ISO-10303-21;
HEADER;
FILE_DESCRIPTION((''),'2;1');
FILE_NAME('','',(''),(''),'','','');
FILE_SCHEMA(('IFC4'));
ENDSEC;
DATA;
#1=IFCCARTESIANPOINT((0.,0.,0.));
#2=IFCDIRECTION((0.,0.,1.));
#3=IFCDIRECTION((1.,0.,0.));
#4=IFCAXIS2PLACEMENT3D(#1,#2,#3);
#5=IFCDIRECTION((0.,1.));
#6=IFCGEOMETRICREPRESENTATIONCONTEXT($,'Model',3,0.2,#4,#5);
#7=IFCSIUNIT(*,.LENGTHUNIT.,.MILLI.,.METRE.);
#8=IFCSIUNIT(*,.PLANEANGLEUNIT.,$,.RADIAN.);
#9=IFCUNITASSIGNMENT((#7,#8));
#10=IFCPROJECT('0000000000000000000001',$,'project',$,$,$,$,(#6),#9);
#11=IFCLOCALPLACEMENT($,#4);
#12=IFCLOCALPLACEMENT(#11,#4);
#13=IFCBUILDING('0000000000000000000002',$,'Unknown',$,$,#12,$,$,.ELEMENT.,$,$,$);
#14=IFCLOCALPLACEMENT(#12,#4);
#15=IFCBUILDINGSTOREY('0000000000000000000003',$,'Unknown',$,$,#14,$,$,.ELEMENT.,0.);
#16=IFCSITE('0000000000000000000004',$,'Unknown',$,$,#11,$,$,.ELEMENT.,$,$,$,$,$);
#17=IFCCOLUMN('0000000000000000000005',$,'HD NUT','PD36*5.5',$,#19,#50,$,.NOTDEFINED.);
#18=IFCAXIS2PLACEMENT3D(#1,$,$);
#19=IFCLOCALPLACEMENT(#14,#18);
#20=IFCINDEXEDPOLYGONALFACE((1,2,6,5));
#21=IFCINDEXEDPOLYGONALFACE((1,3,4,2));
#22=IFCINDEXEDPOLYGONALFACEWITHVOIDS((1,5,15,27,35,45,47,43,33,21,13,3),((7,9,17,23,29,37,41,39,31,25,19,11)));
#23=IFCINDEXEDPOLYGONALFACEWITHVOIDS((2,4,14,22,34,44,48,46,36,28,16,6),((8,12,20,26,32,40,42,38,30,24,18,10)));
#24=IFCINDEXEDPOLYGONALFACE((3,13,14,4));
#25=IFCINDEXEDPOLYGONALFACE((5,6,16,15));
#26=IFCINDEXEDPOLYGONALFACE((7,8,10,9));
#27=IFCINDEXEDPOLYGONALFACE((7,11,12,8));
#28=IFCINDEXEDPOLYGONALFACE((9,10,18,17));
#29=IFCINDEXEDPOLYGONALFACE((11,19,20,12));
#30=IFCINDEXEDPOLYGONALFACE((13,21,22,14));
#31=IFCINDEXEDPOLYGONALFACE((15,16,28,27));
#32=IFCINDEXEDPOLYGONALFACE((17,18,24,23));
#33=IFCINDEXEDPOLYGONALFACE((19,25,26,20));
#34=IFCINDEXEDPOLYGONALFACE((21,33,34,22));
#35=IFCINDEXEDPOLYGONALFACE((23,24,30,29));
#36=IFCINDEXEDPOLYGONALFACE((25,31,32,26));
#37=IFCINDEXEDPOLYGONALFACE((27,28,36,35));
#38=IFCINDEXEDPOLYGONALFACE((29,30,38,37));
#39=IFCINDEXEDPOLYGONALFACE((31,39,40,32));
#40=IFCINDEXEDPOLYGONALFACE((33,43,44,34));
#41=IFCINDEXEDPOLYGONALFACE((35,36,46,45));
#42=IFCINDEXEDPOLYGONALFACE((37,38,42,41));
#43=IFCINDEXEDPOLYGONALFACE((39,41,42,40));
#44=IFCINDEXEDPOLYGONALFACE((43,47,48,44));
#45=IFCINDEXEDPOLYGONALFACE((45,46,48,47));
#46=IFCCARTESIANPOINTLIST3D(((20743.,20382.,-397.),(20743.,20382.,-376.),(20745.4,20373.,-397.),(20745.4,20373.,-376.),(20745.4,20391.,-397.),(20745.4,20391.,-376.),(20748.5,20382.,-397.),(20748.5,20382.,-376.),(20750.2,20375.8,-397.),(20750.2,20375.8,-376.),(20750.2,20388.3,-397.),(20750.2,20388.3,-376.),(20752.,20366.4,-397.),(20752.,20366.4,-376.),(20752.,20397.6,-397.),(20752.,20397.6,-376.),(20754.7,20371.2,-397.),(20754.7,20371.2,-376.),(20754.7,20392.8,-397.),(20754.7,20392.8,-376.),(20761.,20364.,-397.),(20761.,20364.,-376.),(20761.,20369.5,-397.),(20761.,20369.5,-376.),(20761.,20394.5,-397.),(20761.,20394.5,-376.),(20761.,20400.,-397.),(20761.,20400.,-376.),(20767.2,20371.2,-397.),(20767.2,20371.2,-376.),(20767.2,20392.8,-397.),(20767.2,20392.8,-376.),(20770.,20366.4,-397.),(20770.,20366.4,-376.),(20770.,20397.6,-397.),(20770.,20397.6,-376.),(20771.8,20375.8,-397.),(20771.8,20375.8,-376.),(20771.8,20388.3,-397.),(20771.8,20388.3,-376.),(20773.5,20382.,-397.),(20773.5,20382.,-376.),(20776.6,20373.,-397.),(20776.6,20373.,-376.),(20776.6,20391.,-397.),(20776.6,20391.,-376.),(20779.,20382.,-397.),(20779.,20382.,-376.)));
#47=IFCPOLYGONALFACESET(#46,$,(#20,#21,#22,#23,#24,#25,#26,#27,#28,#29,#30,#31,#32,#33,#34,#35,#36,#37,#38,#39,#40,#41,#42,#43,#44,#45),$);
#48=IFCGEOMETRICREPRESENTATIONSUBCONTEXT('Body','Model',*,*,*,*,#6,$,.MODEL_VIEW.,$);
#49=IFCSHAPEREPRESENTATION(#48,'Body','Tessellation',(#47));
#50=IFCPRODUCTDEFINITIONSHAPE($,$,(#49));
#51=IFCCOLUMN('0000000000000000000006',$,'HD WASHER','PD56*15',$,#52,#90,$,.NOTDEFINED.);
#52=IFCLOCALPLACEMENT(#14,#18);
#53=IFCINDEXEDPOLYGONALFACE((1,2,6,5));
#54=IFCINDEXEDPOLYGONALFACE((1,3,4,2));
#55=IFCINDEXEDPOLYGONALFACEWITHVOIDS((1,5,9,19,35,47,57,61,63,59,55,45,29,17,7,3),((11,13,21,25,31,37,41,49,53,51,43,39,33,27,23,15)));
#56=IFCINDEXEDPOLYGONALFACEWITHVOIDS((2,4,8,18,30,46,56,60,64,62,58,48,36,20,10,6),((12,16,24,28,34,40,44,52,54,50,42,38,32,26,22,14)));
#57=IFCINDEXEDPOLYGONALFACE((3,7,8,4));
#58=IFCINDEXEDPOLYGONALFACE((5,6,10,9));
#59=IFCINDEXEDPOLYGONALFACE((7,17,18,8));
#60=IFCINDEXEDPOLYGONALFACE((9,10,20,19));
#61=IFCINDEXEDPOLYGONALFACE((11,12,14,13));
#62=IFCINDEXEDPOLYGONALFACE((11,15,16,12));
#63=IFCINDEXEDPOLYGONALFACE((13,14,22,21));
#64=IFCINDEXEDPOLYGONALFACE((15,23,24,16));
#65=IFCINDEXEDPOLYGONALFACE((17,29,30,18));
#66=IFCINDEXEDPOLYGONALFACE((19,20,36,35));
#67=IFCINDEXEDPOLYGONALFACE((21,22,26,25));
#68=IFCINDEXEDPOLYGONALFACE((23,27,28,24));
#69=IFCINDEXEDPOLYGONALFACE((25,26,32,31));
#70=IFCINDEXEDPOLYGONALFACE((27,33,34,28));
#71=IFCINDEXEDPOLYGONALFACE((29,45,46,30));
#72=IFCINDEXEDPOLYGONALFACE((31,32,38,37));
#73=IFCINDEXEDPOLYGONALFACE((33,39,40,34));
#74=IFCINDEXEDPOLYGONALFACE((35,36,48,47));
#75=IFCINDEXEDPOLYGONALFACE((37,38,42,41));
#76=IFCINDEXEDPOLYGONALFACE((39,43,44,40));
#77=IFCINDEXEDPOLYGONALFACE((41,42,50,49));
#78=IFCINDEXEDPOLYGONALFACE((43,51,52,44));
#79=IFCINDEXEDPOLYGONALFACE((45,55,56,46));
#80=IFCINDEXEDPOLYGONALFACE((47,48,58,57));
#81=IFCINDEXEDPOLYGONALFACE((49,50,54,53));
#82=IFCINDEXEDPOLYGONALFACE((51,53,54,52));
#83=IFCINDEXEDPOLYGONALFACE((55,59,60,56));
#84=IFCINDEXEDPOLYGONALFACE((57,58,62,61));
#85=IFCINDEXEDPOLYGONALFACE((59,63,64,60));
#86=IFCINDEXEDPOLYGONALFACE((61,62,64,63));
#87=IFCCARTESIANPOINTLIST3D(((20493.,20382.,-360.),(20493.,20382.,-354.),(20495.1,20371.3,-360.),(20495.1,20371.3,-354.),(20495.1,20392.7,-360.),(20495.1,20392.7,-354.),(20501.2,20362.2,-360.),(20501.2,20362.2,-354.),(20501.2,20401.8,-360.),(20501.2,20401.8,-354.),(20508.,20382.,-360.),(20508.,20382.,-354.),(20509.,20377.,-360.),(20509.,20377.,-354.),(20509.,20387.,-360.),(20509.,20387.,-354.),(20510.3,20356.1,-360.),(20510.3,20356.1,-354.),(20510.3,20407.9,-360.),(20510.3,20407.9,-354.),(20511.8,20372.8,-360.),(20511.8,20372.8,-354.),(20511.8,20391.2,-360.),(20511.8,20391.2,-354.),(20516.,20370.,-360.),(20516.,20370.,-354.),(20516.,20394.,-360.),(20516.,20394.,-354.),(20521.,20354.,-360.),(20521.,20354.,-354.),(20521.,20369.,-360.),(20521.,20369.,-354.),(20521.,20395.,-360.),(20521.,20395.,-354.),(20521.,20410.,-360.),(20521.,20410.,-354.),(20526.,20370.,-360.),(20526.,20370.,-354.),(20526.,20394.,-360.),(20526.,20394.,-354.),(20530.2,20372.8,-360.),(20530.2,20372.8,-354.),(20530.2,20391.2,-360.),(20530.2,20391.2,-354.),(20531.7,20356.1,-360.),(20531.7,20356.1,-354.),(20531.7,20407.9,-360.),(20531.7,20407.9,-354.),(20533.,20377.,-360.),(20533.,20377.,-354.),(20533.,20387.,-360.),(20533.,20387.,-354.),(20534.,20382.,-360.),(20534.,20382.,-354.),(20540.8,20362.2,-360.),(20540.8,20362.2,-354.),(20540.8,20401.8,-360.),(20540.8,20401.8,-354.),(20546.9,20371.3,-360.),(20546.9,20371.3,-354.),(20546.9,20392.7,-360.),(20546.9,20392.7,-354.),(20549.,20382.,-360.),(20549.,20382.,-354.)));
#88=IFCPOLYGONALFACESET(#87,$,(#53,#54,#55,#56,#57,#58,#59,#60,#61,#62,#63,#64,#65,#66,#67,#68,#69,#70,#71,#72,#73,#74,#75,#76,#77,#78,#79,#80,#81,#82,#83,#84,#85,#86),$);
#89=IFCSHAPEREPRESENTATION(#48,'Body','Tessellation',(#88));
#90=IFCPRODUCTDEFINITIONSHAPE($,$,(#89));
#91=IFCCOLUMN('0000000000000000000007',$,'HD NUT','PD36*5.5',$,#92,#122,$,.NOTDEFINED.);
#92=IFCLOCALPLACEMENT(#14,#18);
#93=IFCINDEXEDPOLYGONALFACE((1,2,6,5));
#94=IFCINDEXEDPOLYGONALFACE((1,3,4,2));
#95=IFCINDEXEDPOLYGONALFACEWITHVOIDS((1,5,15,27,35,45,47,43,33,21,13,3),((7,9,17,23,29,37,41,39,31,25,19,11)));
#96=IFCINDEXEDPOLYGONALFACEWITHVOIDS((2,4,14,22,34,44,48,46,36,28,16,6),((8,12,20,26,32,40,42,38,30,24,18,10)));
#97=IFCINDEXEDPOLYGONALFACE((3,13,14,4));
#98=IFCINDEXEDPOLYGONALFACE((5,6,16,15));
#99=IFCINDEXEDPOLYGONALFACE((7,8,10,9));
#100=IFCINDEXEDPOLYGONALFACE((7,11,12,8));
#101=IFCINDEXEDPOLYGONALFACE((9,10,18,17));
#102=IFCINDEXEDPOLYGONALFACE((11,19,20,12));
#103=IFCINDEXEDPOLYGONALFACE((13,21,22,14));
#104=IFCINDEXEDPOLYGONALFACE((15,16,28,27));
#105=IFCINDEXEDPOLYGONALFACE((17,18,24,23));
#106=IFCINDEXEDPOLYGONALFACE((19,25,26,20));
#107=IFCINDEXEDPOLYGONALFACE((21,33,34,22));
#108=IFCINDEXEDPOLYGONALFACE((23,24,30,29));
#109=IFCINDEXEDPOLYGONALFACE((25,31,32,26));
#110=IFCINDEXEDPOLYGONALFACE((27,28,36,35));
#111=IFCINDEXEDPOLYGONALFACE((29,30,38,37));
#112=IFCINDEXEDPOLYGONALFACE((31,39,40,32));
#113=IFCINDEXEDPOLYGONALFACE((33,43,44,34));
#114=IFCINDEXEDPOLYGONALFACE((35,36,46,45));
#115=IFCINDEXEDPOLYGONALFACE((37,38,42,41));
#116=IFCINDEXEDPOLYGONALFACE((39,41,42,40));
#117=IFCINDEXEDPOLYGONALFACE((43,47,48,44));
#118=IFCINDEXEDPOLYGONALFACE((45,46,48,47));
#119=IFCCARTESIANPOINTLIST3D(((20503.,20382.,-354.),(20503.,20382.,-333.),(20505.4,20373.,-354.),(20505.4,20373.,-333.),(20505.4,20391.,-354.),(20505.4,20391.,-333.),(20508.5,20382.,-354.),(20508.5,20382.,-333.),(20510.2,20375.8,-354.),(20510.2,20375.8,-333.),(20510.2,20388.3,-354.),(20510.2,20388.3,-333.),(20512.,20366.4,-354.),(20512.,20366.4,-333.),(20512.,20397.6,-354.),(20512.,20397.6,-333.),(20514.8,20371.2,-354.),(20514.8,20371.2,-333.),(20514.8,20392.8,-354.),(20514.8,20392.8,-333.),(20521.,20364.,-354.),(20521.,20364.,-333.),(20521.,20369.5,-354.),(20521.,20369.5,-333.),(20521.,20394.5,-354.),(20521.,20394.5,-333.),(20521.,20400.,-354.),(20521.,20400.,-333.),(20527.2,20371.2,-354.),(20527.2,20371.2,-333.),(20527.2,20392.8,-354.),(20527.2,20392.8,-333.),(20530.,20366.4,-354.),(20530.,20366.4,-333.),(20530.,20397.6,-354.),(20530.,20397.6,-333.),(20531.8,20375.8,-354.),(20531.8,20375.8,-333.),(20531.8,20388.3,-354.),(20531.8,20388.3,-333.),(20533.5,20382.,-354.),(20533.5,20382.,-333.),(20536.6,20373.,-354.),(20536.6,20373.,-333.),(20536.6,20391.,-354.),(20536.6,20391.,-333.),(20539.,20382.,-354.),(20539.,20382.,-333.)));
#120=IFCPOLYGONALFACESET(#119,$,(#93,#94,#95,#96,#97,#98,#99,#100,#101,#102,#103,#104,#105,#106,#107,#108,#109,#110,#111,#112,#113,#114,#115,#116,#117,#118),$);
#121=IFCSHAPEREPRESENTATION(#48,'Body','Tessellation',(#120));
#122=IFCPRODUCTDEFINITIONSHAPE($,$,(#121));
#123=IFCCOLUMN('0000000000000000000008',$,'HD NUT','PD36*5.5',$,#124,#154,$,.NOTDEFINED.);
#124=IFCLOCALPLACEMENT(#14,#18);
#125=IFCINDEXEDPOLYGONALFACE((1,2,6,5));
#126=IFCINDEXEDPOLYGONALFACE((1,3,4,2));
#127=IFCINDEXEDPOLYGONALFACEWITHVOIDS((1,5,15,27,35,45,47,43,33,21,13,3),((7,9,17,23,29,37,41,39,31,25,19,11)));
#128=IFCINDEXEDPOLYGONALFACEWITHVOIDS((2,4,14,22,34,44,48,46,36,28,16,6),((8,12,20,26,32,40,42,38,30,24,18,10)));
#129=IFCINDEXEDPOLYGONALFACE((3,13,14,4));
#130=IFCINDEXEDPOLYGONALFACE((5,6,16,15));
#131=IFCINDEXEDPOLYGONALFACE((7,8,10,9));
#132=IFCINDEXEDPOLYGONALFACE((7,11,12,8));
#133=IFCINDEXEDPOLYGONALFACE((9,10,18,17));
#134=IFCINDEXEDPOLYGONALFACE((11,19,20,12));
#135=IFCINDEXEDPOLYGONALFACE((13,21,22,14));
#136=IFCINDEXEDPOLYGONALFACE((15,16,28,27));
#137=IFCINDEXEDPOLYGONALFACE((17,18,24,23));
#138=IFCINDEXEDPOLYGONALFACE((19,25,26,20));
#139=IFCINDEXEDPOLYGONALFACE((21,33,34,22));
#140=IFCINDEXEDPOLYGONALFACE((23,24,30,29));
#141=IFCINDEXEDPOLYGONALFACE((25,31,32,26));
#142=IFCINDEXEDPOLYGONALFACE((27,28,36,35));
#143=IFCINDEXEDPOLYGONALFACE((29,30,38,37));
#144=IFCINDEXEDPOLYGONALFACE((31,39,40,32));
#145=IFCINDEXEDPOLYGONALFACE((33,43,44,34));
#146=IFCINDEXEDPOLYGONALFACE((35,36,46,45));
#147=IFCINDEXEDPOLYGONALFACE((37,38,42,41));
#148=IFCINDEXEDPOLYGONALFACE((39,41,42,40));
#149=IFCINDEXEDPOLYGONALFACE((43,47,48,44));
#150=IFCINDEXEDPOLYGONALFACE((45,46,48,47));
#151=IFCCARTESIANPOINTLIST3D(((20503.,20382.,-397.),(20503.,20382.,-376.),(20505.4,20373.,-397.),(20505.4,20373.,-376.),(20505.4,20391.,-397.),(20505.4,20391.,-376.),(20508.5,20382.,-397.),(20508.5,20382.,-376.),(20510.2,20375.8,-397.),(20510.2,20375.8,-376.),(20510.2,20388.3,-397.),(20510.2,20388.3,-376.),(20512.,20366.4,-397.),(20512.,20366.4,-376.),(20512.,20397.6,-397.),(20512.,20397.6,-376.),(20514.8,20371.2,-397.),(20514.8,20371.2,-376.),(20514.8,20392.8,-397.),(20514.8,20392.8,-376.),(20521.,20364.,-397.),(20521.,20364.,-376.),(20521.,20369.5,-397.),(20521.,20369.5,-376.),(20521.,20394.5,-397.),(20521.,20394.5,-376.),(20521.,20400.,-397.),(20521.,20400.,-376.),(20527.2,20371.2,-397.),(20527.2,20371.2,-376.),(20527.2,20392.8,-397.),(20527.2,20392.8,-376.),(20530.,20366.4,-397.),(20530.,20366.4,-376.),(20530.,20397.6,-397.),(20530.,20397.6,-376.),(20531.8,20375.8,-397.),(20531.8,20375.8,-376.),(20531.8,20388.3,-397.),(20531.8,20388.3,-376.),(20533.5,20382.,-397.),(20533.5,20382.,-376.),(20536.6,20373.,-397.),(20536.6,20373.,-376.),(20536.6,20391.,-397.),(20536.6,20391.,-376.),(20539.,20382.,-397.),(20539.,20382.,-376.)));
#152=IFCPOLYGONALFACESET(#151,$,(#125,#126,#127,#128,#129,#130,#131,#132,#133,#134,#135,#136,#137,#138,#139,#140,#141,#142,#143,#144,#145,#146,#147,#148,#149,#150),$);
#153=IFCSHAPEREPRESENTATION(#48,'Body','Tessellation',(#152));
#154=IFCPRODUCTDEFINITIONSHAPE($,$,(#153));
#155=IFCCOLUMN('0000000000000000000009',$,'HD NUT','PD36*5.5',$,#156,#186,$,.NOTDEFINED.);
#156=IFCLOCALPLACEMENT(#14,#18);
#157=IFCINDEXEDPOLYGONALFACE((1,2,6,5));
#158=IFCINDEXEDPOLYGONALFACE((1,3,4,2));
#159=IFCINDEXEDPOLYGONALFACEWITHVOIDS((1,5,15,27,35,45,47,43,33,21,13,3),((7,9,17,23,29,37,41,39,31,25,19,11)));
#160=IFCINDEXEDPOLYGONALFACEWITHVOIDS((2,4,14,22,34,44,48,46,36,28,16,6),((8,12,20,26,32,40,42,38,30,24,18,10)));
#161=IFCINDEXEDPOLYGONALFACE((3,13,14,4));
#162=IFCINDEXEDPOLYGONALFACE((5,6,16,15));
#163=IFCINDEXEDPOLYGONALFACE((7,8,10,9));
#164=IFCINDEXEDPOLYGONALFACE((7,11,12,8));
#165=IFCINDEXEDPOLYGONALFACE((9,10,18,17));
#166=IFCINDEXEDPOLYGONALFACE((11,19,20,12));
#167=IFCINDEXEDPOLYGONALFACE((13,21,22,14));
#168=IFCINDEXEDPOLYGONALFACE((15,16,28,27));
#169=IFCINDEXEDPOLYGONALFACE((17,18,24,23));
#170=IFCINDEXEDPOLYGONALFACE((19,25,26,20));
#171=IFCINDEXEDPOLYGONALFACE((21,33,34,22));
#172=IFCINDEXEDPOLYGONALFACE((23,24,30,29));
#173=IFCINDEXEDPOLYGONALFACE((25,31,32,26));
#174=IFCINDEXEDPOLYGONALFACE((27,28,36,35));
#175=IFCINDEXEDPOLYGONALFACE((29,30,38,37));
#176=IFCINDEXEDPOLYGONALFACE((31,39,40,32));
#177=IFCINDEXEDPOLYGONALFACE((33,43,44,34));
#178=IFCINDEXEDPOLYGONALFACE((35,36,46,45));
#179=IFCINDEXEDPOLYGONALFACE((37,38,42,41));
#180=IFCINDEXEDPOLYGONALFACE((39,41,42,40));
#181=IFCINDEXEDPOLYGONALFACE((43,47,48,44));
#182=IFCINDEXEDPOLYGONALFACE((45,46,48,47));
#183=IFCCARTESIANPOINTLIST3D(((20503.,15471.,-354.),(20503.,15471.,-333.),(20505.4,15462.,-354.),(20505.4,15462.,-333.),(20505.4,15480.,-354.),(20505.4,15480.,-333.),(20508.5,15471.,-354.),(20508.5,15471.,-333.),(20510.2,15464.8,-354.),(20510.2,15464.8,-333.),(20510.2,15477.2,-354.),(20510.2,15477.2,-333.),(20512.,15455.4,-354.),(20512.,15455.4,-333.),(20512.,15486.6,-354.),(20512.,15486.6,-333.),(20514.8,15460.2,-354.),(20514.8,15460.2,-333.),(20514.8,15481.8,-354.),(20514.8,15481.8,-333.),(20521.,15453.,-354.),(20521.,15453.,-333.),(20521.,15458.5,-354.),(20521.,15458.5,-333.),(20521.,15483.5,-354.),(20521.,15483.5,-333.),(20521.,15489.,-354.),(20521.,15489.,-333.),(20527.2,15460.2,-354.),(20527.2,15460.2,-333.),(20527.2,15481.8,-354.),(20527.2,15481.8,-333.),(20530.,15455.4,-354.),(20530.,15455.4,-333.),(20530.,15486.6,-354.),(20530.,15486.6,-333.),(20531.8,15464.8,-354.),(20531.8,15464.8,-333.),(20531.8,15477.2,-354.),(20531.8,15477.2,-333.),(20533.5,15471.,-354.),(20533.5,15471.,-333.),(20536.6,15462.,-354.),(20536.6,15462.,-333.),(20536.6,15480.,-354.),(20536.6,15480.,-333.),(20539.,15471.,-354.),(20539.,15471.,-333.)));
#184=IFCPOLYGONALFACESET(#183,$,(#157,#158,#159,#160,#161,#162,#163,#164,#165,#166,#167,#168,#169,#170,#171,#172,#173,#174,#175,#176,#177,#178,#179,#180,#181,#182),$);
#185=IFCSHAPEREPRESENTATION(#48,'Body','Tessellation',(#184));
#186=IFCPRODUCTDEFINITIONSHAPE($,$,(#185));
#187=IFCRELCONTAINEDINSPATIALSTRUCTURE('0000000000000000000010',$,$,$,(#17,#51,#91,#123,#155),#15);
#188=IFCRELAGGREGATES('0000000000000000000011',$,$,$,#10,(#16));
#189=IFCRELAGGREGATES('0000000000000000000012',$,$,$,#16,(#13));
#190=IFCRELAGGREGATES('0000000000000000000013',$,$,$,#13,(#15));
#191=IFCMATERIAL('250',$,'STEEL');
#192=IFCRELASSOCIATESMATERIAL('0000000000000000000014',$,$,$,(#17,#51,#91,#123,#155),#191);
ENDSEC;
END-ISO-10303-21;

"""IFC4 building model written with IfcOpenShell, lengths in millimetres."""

from ifc_helpers import new_model, si_unit, direction, frame, origin_with_axes, place, context, subcontext, project, spatial, line, indexed_curve, outline, extrude, material, element, save


model = new_model("IFC4")

# Units and contexts
model_context = context("Model", 3, precision=0.2, world=origin_with_axes(), true_north=direction((0.0, 1.0)))
body_context = subcontext(model_context, "Body", "Model", "MODEL_VIEW")
ifc_project = project(units=[si_unit("LENGTHUNIT", "METRE", prefix="MILLI"), si_unit("PLANEANGLEUNIT", "RADIAN")], contexts=[model_context])

# Site, building, storey
site_placement = place(None, origin_with_axes())
site = spatial("IfcSite", under=ifc_project, at=site_placement, Name="Unknown", CompositionType="ELEMENT")
building_placement = place(site_placement, origin_with_axes())
building = spatial("IfcBuilding", under=site, at=building_placement, Name="Unknown", CompositionType="ELEMENT")
storey_placement = place(building_placement, origin_with_axes())
storey = spatial("IfcBuildingStorey", under=building, at=storey_placement, Name="Unknown", CompositionType="ELEMENT", Elevation=0.0)

# Columns
ifc_material_1 = material(Name="250", Category="STEEL")
column_1_placement = place(storey_placement, frame((20761.0, 20382.0, -397.0), z_axis=(-1.0, 0.0, 0.0), x_axis=(0.0, 0.0, 1.0)))
element("IfcColumn", 1, at=column_1_placement, inside=storey, material=ifc_material_1, Name="HD NUT", Description="PD36*5.5", PredefinedType="NOTDEFINED", context=body_context, shape_type="SolidModel", body=[
    extrude(outline(indexed_curve([(18.0, 0.0), (15.6, 9.0), (9.0, 15.6), (0.0, 18.0), (-9.0, 15.6), (-15.6, 9.0), (-18.0, 0.0), (-15.6, -9.0), (-9.0, -15.6), (0.0, -18.0), (9.0, -15.6), (15.6, -9.0)], segments=[line(1, 2, 3, 4, 5, 6, 7, 8, 9, 10, 11, 12, 1)]), holes=[indexed_curve([(12.5, 0.0), (10.8, -6.2), (6.2, -10.8), (0.0, -12.5), (-6.2, -10.8), (-10.8, -6.2), (-12.5, 0.0), (-10.8, 6.2), (-6.2, 10.8), (0.0, 12.5), (6.2, 10.8), (10.8, 6.2)], segments=[line(1, 2, 3, 4, 5, 6, 7, 8, 9, 10, 11, 12, 1)])]), frame((0.0, 0.0, 0.0), z_axis=(-1.0, 0.0, 0.0), x_axis=(0.0, 0.0, 1.0)), (0.0, 0.0, -1.0), 21.0),
])
column_2_placement = place(storey_placement, frame((20521.0, 20382.0, -360.0), z_axis=(-1.0, 0.0, 0.0), x_axis=(0.0, 0.0, 1.0)))
element("IfcColumn", 2, at=column_2_placement, inside=storey, material=ifc_material_1, Name="HD WASHER", Description="PD56*15", PredefinedType="NOTDEFINED", context=body_context, shape_type="SolidModel", body=[
    extrude(outline(indexed_curve([(28.0, 0.0), (25.9, 10.7), (19.8, 19.8), (10.7, 25.9), (0.0, 28.0), (-10.7, 25.9), (-19.8, 19.8), (-25.9, 10.7), (-28.0, 0.0), (-25.9, -10.7), (-19.8, -19.8), (-10.7, -25.9), (0.0, -28.0), (10.7, -25.9), (19.8, -19.8), (25.9, -10.7)], segments=[line(1, 2, 3, 4, 5, 6, 7, 8, 9, 10, 11, 12, 13, 14, 15, 16, 1)]), holes=[indexed_curve([(13.0, 0.0), (12.0, -5.0), (9.2, -9.2), (5.0, -12.0), (0.0, -13.0), (-5.0, -12.0), (-9.2, -9.2), (-12.0, -5.0), (-13.0, 0.0), (-12.0, 5.0), (-9.2, 9.2), (-5.0, 12.0), (0.0, 13.0), (5.0, 12.0), (9.2, 9.2), (12.0, 5.0)], segments=[line(1, 2, 3, 4, 5, 6, 7, 8, 9, 10, 11, 12, 13, 14, 15, 16, 1)])]), frame((0.0, 0.0, 0.0), z_axis=(-1.0, 0.0, 0.0), x_axis=(0.0, 0.0, 1.0)), (0.0, 0.0, -1.0), 6.0),
])
for number, where, z_axis, x_axis, name in (
    (3, (20521.0, 20382.0, -354.0), (-1.0, 0.0, 0.0), (0.0, 0.0, 1.0), "HD NUT"),
    (4, (20521.0, 20382.0, -397.0), (-1.0, 0.0, 0.0), (0.0, 0.0, 1.0), "HD NUT"),
    (5, (20521.0, 15471.0, -354.0), (-1.0, 0.0, 0.0), (0.0, 0.0, 1.0), "HD NUT"),
):
    element("IfcColumn", number, at=place(storey_placement, frame(where, z_axis=z_axis, x_axis=x_axis)), inside=storey, material=ifc_material_1, Name=name, Description="PD36*5.5", PredefinedType="NOTDEFINED", context=body_context, shape_type="SolidModel", body=[
        extrude(outline(indexed_curve([(18.0, 0.0), (15.6, 9.0), (9.0, 15.6), (0.0, 18.0), (-9.0, 15.6), (-15.6, 9.0), (-18.0, 0.0), (-15.6, -9.0), (-9.0, -15.6), (0.0, -18.0), (9.0, -15.6), (15.6, -9.0)], segments=[line(1, 2, 3, 4, 5, 6, 7, 8, 9, 10, 11, 12, 1)]), holes=[indexed_curve([(12.5, 0.0), (10.8, -6.2), (6.2, -10.8), (0.0, -12.5), (-6.2, -10.8), (-10.8, -6.2), (-12.5, 0.0), (-10.8, 6.2), (-6.2, 10.8), (0.0, 12.5), (6.2, 10.8), (10.8, 6.2)], segments=[line(1, 2, 3, 4, 5, 6, 7, 8, 9, 10, 11, 12, 1)])]), frame((0.0, 0.0, 0.0), z_axis=(-1.0, 0.0, 0.0), x_axis=(0.0, 0.0, 1.0)), (0.0, 0.0, -1.0), 21.0),
    ])

save(model, "model.ifc")
